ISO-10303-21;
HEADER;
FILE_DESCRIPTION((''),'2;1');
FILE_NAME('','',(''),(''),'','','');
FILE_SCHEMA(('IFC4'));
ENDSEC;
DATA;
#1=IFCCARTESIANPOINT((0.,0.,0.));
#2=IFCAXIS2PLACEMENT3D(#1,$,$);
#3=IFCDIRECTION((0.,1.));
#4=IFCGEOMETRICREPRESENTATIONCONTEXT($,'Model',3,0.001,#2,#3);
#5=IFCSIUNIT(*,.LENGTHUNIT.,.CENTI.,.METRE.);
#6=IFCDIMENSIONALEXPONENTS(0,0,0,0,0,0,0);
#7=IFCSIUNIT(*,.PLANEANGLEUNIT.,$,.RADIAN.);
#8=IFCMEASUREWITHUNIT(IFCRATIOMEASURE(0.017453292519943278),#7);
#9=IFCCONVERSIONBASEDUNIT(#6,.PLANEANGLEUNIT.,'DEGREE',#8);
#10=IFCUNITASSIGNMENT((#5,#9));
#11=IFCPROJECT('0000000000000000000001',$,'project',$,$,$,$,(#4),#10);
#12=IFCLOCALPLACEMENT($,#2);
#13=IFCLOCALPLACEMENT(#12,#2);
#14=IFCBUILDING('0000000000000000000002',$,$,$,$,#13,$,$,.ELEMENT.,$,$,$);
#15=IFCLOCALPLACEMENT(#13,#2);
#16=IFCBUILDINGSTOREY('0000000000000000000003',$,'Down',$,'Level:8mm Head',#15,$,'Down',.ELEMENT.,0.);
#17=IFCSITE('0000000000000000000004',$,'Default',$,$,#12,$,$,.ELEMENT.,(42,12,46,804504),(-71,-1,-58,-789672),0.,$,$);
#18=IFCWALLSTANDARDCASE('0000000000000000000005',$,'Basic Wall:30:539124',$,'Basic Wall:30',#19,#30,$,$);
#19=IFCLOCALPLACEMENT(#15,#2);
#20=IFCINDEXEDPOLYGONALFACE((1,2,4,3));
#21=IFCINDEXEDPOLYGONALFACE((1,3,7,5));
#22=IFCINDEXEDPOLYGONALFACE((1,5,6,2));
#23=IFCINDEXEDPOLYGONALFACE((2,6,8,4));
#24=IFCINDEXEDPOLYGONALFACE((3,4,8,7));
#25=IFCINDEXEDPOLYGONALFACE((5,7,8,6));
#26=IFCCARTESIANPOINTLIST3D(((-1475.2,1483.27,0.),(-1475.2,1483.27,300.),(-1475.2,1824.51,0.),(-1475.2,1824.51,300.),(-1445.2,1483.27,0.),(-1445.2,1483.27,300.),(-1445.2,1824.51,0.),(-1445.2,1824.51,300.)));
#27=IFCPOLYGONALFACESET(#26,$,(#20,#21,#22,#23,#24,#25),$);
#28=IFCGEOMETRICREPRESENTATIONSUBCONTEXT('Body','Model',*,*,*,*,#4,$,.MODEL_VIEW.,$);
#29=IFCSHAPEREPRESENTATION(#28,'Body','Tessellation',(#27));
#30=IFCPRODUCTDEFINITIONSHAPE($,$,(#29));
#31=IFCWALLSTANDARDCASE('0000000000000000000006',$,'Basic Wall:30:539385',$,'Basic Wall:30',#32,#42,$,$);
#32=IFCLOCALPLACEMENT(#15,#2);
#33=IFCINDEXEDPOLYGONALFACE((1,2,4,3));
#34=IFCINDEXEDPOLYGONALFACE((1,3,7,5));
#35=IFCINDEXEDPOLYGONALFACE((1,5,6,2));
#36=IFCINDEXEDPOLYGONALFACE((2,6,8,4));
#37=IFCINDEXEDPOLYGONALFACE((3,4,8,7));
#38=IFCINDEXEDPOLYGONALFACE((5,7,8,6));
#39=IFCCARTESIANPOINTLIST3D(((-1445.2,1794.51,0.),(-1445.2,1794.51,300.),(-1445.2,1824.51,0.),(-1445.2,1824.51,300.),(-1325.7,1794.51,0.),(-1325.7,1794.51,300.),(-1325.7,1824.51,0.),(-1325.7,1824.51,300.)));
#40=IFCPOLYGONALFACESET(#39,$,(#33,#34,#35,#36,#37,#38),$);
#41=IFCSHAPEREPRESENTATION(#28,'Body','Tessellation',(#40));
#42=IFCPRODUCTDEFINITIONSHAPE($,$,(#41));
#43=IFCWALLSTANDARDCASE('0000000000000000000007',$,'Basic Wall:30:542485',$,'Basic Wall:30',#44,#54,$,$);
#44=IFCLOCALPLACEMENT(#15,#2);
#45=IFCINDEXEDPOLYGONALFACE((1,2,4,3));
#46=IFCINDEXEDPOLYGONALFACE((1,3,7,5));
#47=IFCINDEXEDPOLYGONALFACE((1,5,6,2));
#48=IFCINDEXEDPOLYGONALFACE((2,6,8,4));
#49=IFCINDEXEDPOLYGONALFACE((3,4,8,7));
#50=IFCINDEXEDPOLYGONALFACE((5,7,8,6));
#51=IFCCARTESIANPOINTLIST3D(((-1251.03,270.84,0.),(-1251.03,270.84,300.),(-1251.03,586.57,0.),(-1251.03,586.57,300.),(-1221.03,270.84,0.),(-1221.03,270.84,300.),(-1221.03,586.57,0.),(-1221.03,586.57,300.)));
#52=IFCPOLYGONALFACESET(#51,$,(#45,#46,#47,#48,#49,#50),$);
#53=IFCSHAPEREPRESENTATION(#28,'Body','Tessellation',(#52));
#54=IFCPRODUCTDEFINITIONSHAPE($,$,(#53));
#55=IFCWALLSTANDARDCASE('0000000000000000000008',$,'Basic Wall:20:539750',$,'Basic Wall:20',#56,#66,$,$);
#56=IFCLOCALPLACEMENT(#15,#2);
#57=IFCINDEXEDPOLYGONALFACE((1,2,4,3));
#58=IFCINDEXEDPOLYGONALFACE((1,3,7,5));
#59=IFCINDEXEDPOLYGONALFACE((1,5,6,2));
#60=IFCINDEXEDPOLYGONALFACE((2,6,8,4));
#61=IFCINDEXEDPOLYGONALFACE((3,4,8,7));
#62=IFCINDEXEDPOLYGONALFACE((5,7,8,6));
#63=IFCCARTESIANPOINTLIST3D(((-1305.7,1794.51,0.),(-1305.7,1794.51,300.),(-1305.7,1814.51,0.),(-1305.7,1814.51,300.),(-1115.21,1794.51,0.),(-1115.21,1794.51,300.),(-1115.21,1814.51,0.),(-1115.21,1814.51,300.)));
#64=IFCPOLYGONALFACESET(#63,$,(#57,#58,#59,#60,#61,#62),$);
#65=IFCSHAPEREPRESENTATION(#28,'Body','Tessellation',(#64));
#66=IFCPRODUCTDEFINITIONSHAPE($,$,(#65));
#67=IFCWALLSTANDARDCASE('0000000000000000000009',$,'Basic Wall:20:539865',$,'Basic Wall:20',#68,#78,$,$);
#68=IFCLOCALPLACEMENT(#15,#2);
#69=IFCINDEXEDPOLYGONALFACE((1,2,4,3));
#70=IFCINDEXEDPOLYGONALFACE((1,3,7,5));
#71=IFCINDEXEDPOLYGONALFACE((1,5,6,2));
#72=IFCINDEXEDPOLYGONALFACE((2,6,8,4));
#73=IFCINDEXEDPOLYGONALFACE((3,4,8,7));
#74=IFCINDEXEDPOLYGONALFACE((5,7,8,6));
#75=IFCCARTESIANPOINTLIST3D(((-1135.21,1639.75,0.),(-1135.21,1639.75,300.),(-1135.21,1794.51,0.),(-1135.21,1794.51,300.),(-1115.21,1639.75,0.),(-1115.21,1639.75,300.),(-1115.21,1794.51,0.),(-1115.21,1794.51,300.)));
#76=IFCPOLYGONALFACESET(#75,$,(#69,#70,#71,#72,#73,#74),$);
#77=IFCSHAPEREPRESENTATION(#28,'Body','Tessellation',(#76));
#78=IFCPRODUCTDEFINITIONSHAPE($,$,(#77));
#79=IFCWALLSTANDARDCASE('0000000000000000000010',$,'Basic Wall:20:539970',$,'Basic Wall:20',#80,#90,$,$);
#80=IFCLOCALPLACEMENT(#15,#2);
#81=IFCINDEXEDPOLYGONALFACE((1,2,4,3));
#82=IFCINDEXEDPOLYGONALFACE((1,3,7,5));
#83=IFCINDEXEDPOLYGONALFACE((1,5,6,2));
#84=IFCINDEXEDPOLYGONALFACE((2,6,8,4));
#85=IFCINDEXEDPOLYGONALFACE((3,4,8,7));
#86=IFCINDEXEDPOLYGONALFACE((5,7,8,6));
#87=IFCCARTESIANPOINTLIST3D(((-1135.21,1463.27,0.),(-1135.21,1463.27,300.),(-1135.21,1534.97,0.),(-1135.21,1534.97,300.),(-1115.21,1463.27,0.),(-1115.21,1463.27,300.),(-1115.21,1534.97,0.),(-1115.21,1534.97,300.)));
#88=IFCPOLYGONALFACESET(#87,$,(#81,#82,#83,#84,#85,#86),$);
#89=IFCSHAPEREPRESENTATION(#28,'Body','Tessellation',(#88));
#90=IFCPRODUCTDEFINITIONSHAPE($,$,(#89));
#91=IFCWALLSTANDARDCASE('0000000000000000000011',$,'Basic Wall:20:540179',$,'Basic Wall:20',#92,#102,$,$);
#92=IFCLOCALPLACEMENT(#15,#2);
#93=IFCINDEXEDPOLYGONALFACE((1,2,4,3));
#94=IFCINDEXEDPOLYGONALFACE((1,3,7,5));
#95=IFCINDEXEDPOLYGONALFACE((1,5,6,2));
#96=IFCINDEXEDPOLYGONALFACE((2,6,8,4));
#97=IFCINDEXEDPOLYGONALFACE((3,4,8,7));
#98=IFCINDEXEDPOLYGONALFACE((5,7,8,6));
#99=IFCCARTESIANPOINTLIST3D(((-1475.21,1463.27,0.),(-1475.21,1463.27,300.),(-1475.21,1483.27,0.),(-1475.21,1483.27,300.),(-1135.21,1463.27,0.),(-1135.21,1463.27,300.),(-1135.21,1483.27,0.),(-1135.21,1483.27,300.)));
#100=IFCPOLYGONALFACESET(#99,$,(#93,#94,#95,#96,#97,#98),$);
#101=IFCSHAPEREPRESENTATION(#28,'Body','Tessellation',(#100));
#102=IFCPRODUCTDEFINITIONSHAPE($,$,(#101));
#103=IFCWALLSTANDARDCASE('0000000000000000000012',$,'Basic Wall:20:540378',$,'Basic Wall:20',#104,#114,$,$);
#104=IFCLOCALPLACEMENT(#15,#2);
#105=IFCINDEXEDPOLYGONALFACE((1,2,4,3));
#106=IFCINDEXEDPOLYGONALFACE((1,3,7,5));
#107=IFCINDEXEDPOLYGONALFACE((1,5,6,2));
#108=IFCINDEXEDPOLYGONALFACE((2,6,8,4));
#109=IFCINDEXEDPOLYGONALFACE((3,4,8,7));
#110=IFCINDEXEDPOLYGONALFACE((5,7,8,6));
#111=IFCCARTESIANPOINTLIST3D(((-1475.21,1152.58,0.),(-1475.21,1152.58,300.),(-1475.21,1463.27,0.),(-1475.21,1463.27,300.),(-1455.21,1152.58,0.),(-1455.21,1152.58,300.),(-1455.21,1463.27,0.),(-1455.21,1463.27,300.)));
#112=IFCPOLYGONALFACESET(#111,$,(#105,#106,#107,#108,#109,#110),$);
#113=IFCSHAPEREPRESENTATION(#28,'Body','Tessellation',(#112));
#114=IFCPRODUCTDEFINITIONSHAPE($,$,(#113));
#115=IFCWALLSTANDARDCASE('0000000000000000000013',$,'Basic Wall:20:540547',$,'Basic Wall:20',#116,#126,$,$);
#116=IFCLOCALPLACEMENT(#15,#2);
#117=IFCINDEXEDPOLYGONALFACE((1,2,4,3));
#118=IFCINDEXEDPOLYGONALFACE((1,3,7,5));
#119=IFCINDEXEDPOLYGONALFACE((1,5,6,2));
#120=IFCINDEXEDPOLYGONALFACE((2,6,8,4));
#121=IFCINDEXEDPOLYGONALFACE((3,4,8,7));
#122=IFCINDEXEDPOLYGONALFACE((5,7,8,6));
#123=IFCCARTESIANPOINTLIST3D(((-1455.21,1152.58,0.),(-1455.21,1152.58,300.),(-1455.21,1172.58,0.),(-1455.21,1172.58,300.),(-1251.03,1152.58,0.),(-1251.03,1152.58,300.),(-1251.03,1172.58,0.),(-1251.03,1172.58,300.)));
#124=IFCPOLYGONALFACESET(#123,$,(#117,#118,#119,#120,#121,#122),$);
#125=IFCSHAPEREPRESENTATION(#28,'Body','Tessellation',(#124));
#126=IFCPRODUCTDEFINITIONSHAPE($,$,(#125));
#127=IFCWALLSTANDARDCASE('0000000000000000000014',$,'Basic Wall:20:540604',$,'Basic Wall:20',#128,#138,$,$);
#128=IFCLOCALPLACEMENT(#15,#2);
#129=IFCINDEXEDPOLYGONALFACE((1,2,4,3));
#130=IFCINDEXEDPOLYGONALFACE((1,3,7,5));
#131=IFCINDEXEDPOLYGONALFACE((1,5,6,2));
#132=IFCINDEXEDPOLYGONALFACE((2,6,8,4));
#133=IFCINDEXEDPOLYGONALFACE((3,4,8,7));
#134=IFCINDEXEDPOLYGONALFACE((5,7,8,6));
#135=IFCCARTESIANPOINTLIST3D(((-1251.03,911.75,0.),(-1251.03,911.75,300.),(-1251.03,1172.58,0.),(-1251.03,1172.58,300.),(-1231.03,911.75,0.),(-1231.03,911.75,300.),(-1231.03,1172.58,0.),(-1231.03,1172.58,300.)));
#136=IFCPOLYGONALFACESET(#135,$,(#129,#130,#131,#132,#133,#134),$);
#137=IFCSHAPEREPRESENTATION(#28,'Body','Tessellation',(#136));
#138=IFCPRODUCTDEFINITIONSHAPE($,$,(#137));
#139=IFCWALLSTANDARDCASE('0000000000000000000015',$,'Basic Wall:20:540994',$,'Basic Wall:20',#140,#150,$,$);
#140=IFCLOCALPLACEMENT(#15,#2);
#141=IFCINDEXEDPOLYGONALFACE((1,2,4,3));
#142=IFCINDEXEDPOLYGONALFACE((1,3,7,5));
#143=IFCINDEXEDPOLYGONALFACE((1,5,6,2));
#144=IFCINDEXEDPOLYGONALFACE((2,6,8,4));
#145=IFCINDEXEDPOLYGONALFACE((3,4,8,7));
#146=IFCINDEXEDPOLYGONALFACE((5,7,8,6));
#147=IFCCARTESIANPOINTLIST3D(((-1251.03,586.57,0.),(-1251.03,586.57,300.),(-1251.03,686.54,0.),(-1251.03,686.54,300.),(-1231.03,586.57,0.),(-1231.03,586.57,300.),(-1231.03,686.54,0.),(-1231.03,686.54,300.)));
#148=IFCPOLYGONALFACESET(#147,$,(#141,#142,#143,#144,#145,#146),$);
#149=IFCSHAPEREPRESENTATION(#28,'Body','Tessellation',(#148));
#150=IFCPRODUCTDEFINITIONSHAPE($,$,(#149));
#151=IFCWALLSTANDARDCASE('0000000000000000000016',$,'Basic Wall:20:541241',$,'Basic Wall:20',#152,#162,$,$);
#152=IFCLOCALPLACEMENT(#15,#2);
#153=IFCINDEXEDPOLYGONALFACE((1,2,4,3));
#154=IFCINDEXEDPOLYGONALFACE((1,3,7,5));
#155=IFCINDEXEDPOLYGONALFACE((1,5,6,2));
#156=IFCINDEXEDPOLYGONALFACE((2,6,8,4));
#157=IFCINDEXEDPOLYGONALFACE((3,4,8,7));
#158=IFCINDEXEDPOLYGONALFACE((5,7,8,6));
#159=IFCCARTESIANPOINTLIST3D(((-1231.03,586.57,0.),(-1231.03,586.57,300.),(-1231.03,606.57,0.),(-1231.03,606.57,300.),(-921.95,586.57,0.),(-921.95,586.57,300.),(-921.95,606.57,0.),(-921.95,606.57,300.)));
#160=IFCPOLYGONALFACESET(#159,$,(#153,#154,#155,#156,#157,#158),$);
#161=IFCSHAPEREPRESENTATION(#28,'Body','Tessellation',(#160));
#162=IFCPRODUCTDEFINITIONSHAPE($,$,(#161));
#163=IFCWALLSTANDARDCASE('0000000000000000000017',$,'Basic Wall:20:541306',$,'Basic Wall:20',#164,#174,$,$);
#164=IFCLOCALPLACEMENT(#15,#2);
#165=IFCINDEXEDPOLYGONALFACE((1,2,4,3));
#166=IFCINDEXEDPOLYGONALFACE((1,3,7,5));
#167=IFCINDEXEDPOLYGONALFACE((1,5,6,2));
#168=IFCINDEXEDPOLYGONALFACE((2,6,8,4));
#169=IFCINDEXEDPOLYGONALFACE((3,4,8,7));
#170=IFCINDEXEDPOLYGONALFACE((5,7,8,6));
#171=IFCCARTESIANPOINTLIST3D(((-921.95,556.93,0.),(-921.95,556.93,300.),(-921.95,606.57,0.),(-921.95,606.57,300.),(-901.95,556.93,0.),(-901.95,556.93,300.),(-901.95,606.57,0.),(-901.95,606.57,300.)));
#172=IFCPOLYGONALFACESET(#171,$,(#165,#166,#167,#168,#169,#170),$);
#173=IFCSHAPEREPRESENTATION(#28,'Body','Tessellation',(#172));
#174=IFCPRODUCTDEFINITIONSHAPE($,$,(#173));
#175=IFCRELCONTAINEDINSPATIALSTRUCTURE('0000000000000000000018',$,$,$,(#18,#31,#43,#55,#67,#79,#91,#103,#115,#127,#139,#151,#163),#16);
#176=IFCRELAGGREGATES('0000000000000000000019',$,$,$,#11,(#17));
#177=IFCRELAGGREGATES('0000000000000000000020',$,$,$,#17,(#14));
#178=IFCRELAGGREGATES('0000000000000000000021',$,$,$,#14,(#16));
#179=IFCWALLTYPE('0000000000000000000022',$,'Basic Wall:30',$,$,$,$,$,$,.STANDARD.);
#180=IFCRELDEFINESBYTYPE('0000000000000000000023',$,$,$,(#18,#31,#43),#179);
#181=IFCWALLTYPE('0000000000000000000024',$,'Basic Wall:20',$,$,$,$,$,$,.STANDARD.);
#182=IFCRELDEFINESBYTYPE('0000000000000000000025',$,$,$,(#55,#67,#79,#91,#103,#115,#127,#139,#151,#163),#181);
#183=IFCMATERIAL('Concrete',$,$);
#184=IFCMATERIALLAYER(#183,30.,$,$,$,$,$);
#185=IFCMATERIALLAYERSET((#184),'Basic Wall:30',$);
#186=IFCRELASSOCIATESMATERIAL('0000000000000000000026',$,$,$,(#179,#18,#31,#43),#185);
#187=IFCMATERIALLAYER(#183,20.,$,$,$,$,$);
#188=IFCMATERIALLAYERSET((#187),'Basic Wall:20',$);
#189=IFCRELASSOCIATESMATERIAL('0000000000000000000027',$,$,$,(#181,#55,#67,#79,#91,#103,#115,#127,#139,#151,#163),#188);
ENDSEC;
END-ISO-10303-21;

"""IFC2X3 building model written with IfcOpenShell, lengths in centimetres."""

from ifc_helpers import new_model, entity, si_unit, converted_unit, direction, frame, frame_2d, origin, place, context, subcontext, project, spatial, rectangle, extrude, material, layer, layer_set, layer_usage, type_object, element, save


model = new_model("IFC2X3")

# Units and contexts
model_context = context("Model", 3, precision=0.001, world=origin(), true_north=direction((0.0, 1.0)))
body_context = subcontext(model_context, "Body", "Model", "MODEL_VIEW")
ifc_project = project(units=[si_unit("LENGTHUNIT", "METRE", prefix="CENTI"), converted_unit("PLANEANGLEUNIT", "DEGREE", entity("IfcRatioMeasure", 0.017453292519943278), si_unit("PLANEANGLEUNIT", "RADIAN"), dimensions=[0, 0, 0, 0, 0, 0, 0])], contexts=[model_context])

# Site, building, storey
site_placement = place(None, origin())
site = spatial("IfcSite", under=ifc_project, at=site_placement, Name="Default", CompositionType="ELEMENT", RefLatitude=(42, 12, 46, 804504), RefLongitude=(-71, -1, -58, -789672), RefElevation=0.0)
building_placement = place(site_placement, origin())
building = spatial("IfcBuilding", under=site, at=building_placement, CompositionType="ELEMENT")
storey_placement = place(building_placement, origin())
storey = spatial("IfcBuildingStorey", under=building, at=storey_placement, Name="Down", ObjectType="Level:8mm Head", LongName="Down", CompositionType="ELEMENT", Elevation=0.0)

# Walls
ifc_material = material(Name="Concrete")
ifc_layer_1 = layer(ifc_material, 30.0)
ifc_layer_set_1 = layer_set([ifc_layer_1], Name="Basic Wall:30")
ifc_layer_usage_1 = layer_usage(ifc_layer_set_1, "AXIS2", "NEGATIVE", 15.0)
wall_type_1 = type_object("IfcWallType", Name="Basic Wall:30", PredefinedType="STANDARD", material=ifc_layer_set_1)
wall_1_placement = place(storey_placement, frame((-1460.2, 1483.27, 0.0), z_axis=(0.0, 0.0, 1.0), x_axis=(0.0, 1.0, 0.0)))
element("IfcWallStandardCase", 1, at=wall_1_placement, inside=storey, type_object=wall_type_1, material=ifc_layer_usage_1, Name="Basic Wall:30:539124", ObjectType="Basic Wall:30", context=body_context, shape_type="SweptSolid", body=[
    extrude(rectangle(XDim=341.25, YDim=30.0, at=frame_2d((170.62, 0.0), x_axis=(-1.0, 0.0))), origin(), (0.0, 0.0, 1.0), 300.0),
])
ifc_layer_usage_2 = layer_usage(ifc_layer_set_1, "AXIS2", "NEGATIVE", 15.0)
wall_2_placement = place(storey_placement, frame((-1445.2, 1809.51, 0.0)))
element("IfcWallStandardCase", 2, at=wall_2_placement, inside=storey, type_object=wall_type_1, material=ifc_layer_usage_2, Name="Basic Wall:30:539385", ObjectType="Basic Wall:30", context=body_context, shape_type="SweptSolid", body=[
    extrude(rectangle(XDim=119.5, YDim=30.0, at=frame_2d((59.75, 0.0), x_axis=(-1.0, 0.0))), origin(), (0.0, 0.0, 1.0), 300.0),
])
ifc_layer_usage_3 = layer_usage(ifc_layer_set_1, "AXIS2", "POSITIVE", -15.0)
wall_3_placement = place(storey_placement, frame((-1236.03, 586.57, 0.0), z_axis=(0.0, 0.0, 1.0), x_axis=(0.0, -1.0, 0.0)))
element("IfcWallStandardCase", 3, at=wall_3_placement, inside=storey, type_object=wall_type_1, material=ifc_layer_usage_3, Name="Basic Wall:30:542485", ObjectType="Basic Wall:30", context=body_context, shape_type="SweptSolid", body=[
    extrude(rectangle(XDim=315.73, YDim=30.0, at=frame_2d((157.87, 0.0), x_axis=(-1.0, 0.0))), origin(), (0.0, 0.0, 1.0), 300.0),
])
ifc_layer_2 = layer(ifc_material, 20.0)
ifc_layer_set_2 = layer_set([ifc_layer_2], Name="Basic Wall:20")
ifc_layer_usage_4 = layer_usage(ifc_layer_set_2, "AXIS2", "POSITIVE", -10.0)
wall_type_2 = type_object("IfcWallType", Name="Basic Wall:20", PredefinedType="STANDARD", material=ifc_layer_set_2)
wall_4_placement = place(storey_placement, frame((-1305.7, 1804.51, 0.0)))
element("IfcWallStandardCase", 4, at=wall_4_placement, inside=storey, type_object=wall_type_2, material=ifc_layer_usage_4, Name="Basic Wall:20:539750", ObjectType="Basic Wall:20", context=body_context, shape_type="SweptSolid", body=[
    extrude(rectangle(XDim=190.5, YDim=20.0, at=frame_2d((95.25, 0.0), x_axis=(-1.0, 0.0))), origin(), (0.0, 0.0, 1.0), 300.0),
])
ifc_layer_usage_5 = layer_usage(ifc_layer_set_2, "AXIS2", "NEGATIVE", 10.0)
wall_5_placement = place(storey_placement, frame((-1125.21, 1794.51, 0.0), z_axis=(0.0, 0.0, 1.0), x_axis=(0.0, -1.0, 0.0)))
element("IfcWallStandardCase", 5, at=wall_5_placement, inside=storey, type_object=wall_type_2, material=ifc_layer_usage_5, Name="Basic Wall:20:539865", ObjectType="Basic Wall:20", context=body_context, shape_type="SweptSolid", body=[
    extrude(rectangle(XDim=154.76, YDim=20.0, at=frame_2d((77.38, 0.0), x_axis=(-1.0, 0.0))), origin(), (0.0, 0.0, 1.0), 300.0),
])
ifc_layer_usage_6 = layer_usage(ifc_layer_set_2, "AXIS2", "NEGATIVE", 10.0)
wall_6_placement = place(storey_placement, frame((-1125.21, 1534.97, 0.0), z_axis=(0.0, 0.0, 1.0), x_axis=(0.0, -1.0, 0.0)))
element("IfcWallStandardCase", 6, at=wall_6_placement, inside=storey, type_object=wall_type_2, material=ifc_layer_usage_6, Name="Basic Wall:20:539970", ObjectType="Basic Wall:20", context=body_context, shape_type="SweptSolid", body=[
    extrude(rectangle(XDim=71.7, YDim=20.0, at=frame_2d((35.85, 0.0), x_axis=(-1.0, 0.0))), origin(), (0.0, 0.0, 1.0), 300.0),
])
ifc_layer_usage_7 = layer_usage(ifc_layer_set_2, "AXIS2", "NEGATIVE", 10.0)
wall_7_placement = place(storey_placement, frame((-1135.21, 1473.27, 0.0), z_axis=(0.0, 0.0, 1.0), x_axis=(-1.0, 0.0, 0.0)))
element("IfcWallStandardCase", 7, at=wall_7_placement, inside=storey, type_object=wall_type_2, material=ifc_layer_usage_7, Name="Basic Wall:20:540179", ObjectType="Basic Wall:20", context=body_context, shape_type="SweptSolid", body=[
    extrude(rectangle(XDim=340.0, YDim=20.0, at=frame_2d((170.0, 0.0), x_axis=(-1.0, 0.0))), origin(), (0.0, 0.0, 1.0), 300.0),
])
ifc_layer_usage_8 = layer_usage(ifc_layer_set_2, "AXIS2", "POSITIVE", -10.0)
wall_8_placement = place(storey_placement, frame((-1465.21, 1463.27, 0.0), z_axis=(0.0, 0.0, 1.0), x_axis=(0.0, -1.0, 0.0)))
element("IfcWallStandardCase", 8, at=wall_8_placement, inside=storey, type_object=wall_type_2, material=ifc_layer_usage_8, Name="Basic Wall:20:540378", ObjectType="Basic Wall:20", context=body_context, shape_type="SweptSolid", body=[
    extrude(rectangle(XDim=310.69, YDim=20.0, at=frame_2d((155.35, 0.0), x_axis=(-1.0, 0.0))), origin(), (0.0, 0.0, 1.0), 300.0),
])
ifc_layer_usage_9 = layer_usage(ifc_layer_set_2, "AXIS2", "POSITIVE", -10.0)
wall_9_placement = place(storey_placement, frame((-1455.21, 1162.58, 0.0)))
element("IfcWallStandardCase", 9, at=wall_9_placement, inside=storey, type_object=wall_type_2, material=ifc_layer_usage_9, Name="Basic Wall:20:540547", ObjectType="Basic Wall:20", context=body_context, shape_type="SweptSolid", body=[
    extrude(rectangle(XDim=204.18, YDim=20.0, at=frame_2d((102.09, 0.0), x_axis=(-1.0, 0.0))), origin(), (0.0, 0.0, 1.0), 300.0),
])
ifc_layer_usage_10 = layer_usage(ifc_layer_set_2, "AXIS2", "NEGATIVE", 10.0)
wall_10_placement = place(storey_placement, frame((-1241.03, 1172.58, 0.0), z_axis=(0.0, 0.0, 1.0), x_axis=(0.0, -1.0, 0.0)))
element("IfcWallStandardCase", 10, at=wall_10_placement, inside=storey, type_object=wall_type_2, material=ifc_layer_usage_10, Name="Basic Wall:20:540604", ObjectType="Basic Wall:20", context=body_context, shape_type="SweptSolid", body=[
    extrude(rectangle(XDim=260.83, YDim=20.0, at=frame_2d((130.42, 0.0), x_axis=(-1.0, 0.0))), origin(), (0.0, 0.0, 1.0), 300.0),
])
ifc_layer_usage_11 = layer_usage(ifc_layer_set_2, "AXIS2", "NEGATIVE", 10.0)
wall_11_placement = place(storey_placement, frame((-1241.03, 686.54, 0.0), z_axis=(0.0, 0.0, 1.0), x_axis=(0.0, -1.0, 0.0)))
element("IfcWallStandardCase", 11, at=wall_11_placement, inside=storey, type_object=wall_type_2, material=ifc_layer_usage_11, Name="Basic Wall:20:540994", ObjectType="Basic Wall:20", context=body_context, shape_type="SweptSolid", body=[
    extrude(rectangle(XDim=99.97, YDim=20.0, at=frame_2d((49.99, 0.0), x_axis=(-1.0, 0.0))), origin(), (0.0, 0.0, 1.0), 300.0),
])
ifc_layer_usage_12 = layer_usage(ifc_layer_set_2, "AXIS2", "NEGATIVE", 10.0)
wall_12_placement = place(storey_placement, frame((-1231.03, 596.57, 0.0)))
element("IfcWallStandardCase", 12, at=wall_12_placement, inside=storey, type_object=wall_type_2, material=ifc_layer_usage_12, Name="Basic Wall:20:541241", ObjectType="Basic Wall:20", context=body_context, shape_type="SweptSolid", body=[
    extrude(rectangle(XDim=309.07, YDim=20.0, at=frame_2d((154.54, 0.0), x_axis=(-1.0, 0.0))), origin(), (0.0, 0.0, 1.0), 300.0),
])
ifc_layer_usage_13 = layer_usage(ifc_layer_set_2, "AXIS2", "NEGATIVE", 10.0)
wall_13_placement = place(storey_placement, frame((-911.95, 606.57, 0.0), z_axis=(0.0, 0.0, 1.0), x_axis=(0.0, -1.0, 0.0)))
element("IfcWallStandardCase", 13, at=wall_13_placement, inside=storey, type_object=wall_type_2, material=ifc_layer_usage_13, Name="Basic Wall:20:541306", ObjectType="Basic Wall:20", context=body_context, shape_type="SweptSolid", body=[
    extrude(rectangle(XDim=49.64, YDim=20.0, at=frame_2d((24.82, 0.0), x_axis=(-1.0, 0.0))), origin(), (0.0, 0.0, 1.0), 300.0),
])

save(model, "model.ifc")
